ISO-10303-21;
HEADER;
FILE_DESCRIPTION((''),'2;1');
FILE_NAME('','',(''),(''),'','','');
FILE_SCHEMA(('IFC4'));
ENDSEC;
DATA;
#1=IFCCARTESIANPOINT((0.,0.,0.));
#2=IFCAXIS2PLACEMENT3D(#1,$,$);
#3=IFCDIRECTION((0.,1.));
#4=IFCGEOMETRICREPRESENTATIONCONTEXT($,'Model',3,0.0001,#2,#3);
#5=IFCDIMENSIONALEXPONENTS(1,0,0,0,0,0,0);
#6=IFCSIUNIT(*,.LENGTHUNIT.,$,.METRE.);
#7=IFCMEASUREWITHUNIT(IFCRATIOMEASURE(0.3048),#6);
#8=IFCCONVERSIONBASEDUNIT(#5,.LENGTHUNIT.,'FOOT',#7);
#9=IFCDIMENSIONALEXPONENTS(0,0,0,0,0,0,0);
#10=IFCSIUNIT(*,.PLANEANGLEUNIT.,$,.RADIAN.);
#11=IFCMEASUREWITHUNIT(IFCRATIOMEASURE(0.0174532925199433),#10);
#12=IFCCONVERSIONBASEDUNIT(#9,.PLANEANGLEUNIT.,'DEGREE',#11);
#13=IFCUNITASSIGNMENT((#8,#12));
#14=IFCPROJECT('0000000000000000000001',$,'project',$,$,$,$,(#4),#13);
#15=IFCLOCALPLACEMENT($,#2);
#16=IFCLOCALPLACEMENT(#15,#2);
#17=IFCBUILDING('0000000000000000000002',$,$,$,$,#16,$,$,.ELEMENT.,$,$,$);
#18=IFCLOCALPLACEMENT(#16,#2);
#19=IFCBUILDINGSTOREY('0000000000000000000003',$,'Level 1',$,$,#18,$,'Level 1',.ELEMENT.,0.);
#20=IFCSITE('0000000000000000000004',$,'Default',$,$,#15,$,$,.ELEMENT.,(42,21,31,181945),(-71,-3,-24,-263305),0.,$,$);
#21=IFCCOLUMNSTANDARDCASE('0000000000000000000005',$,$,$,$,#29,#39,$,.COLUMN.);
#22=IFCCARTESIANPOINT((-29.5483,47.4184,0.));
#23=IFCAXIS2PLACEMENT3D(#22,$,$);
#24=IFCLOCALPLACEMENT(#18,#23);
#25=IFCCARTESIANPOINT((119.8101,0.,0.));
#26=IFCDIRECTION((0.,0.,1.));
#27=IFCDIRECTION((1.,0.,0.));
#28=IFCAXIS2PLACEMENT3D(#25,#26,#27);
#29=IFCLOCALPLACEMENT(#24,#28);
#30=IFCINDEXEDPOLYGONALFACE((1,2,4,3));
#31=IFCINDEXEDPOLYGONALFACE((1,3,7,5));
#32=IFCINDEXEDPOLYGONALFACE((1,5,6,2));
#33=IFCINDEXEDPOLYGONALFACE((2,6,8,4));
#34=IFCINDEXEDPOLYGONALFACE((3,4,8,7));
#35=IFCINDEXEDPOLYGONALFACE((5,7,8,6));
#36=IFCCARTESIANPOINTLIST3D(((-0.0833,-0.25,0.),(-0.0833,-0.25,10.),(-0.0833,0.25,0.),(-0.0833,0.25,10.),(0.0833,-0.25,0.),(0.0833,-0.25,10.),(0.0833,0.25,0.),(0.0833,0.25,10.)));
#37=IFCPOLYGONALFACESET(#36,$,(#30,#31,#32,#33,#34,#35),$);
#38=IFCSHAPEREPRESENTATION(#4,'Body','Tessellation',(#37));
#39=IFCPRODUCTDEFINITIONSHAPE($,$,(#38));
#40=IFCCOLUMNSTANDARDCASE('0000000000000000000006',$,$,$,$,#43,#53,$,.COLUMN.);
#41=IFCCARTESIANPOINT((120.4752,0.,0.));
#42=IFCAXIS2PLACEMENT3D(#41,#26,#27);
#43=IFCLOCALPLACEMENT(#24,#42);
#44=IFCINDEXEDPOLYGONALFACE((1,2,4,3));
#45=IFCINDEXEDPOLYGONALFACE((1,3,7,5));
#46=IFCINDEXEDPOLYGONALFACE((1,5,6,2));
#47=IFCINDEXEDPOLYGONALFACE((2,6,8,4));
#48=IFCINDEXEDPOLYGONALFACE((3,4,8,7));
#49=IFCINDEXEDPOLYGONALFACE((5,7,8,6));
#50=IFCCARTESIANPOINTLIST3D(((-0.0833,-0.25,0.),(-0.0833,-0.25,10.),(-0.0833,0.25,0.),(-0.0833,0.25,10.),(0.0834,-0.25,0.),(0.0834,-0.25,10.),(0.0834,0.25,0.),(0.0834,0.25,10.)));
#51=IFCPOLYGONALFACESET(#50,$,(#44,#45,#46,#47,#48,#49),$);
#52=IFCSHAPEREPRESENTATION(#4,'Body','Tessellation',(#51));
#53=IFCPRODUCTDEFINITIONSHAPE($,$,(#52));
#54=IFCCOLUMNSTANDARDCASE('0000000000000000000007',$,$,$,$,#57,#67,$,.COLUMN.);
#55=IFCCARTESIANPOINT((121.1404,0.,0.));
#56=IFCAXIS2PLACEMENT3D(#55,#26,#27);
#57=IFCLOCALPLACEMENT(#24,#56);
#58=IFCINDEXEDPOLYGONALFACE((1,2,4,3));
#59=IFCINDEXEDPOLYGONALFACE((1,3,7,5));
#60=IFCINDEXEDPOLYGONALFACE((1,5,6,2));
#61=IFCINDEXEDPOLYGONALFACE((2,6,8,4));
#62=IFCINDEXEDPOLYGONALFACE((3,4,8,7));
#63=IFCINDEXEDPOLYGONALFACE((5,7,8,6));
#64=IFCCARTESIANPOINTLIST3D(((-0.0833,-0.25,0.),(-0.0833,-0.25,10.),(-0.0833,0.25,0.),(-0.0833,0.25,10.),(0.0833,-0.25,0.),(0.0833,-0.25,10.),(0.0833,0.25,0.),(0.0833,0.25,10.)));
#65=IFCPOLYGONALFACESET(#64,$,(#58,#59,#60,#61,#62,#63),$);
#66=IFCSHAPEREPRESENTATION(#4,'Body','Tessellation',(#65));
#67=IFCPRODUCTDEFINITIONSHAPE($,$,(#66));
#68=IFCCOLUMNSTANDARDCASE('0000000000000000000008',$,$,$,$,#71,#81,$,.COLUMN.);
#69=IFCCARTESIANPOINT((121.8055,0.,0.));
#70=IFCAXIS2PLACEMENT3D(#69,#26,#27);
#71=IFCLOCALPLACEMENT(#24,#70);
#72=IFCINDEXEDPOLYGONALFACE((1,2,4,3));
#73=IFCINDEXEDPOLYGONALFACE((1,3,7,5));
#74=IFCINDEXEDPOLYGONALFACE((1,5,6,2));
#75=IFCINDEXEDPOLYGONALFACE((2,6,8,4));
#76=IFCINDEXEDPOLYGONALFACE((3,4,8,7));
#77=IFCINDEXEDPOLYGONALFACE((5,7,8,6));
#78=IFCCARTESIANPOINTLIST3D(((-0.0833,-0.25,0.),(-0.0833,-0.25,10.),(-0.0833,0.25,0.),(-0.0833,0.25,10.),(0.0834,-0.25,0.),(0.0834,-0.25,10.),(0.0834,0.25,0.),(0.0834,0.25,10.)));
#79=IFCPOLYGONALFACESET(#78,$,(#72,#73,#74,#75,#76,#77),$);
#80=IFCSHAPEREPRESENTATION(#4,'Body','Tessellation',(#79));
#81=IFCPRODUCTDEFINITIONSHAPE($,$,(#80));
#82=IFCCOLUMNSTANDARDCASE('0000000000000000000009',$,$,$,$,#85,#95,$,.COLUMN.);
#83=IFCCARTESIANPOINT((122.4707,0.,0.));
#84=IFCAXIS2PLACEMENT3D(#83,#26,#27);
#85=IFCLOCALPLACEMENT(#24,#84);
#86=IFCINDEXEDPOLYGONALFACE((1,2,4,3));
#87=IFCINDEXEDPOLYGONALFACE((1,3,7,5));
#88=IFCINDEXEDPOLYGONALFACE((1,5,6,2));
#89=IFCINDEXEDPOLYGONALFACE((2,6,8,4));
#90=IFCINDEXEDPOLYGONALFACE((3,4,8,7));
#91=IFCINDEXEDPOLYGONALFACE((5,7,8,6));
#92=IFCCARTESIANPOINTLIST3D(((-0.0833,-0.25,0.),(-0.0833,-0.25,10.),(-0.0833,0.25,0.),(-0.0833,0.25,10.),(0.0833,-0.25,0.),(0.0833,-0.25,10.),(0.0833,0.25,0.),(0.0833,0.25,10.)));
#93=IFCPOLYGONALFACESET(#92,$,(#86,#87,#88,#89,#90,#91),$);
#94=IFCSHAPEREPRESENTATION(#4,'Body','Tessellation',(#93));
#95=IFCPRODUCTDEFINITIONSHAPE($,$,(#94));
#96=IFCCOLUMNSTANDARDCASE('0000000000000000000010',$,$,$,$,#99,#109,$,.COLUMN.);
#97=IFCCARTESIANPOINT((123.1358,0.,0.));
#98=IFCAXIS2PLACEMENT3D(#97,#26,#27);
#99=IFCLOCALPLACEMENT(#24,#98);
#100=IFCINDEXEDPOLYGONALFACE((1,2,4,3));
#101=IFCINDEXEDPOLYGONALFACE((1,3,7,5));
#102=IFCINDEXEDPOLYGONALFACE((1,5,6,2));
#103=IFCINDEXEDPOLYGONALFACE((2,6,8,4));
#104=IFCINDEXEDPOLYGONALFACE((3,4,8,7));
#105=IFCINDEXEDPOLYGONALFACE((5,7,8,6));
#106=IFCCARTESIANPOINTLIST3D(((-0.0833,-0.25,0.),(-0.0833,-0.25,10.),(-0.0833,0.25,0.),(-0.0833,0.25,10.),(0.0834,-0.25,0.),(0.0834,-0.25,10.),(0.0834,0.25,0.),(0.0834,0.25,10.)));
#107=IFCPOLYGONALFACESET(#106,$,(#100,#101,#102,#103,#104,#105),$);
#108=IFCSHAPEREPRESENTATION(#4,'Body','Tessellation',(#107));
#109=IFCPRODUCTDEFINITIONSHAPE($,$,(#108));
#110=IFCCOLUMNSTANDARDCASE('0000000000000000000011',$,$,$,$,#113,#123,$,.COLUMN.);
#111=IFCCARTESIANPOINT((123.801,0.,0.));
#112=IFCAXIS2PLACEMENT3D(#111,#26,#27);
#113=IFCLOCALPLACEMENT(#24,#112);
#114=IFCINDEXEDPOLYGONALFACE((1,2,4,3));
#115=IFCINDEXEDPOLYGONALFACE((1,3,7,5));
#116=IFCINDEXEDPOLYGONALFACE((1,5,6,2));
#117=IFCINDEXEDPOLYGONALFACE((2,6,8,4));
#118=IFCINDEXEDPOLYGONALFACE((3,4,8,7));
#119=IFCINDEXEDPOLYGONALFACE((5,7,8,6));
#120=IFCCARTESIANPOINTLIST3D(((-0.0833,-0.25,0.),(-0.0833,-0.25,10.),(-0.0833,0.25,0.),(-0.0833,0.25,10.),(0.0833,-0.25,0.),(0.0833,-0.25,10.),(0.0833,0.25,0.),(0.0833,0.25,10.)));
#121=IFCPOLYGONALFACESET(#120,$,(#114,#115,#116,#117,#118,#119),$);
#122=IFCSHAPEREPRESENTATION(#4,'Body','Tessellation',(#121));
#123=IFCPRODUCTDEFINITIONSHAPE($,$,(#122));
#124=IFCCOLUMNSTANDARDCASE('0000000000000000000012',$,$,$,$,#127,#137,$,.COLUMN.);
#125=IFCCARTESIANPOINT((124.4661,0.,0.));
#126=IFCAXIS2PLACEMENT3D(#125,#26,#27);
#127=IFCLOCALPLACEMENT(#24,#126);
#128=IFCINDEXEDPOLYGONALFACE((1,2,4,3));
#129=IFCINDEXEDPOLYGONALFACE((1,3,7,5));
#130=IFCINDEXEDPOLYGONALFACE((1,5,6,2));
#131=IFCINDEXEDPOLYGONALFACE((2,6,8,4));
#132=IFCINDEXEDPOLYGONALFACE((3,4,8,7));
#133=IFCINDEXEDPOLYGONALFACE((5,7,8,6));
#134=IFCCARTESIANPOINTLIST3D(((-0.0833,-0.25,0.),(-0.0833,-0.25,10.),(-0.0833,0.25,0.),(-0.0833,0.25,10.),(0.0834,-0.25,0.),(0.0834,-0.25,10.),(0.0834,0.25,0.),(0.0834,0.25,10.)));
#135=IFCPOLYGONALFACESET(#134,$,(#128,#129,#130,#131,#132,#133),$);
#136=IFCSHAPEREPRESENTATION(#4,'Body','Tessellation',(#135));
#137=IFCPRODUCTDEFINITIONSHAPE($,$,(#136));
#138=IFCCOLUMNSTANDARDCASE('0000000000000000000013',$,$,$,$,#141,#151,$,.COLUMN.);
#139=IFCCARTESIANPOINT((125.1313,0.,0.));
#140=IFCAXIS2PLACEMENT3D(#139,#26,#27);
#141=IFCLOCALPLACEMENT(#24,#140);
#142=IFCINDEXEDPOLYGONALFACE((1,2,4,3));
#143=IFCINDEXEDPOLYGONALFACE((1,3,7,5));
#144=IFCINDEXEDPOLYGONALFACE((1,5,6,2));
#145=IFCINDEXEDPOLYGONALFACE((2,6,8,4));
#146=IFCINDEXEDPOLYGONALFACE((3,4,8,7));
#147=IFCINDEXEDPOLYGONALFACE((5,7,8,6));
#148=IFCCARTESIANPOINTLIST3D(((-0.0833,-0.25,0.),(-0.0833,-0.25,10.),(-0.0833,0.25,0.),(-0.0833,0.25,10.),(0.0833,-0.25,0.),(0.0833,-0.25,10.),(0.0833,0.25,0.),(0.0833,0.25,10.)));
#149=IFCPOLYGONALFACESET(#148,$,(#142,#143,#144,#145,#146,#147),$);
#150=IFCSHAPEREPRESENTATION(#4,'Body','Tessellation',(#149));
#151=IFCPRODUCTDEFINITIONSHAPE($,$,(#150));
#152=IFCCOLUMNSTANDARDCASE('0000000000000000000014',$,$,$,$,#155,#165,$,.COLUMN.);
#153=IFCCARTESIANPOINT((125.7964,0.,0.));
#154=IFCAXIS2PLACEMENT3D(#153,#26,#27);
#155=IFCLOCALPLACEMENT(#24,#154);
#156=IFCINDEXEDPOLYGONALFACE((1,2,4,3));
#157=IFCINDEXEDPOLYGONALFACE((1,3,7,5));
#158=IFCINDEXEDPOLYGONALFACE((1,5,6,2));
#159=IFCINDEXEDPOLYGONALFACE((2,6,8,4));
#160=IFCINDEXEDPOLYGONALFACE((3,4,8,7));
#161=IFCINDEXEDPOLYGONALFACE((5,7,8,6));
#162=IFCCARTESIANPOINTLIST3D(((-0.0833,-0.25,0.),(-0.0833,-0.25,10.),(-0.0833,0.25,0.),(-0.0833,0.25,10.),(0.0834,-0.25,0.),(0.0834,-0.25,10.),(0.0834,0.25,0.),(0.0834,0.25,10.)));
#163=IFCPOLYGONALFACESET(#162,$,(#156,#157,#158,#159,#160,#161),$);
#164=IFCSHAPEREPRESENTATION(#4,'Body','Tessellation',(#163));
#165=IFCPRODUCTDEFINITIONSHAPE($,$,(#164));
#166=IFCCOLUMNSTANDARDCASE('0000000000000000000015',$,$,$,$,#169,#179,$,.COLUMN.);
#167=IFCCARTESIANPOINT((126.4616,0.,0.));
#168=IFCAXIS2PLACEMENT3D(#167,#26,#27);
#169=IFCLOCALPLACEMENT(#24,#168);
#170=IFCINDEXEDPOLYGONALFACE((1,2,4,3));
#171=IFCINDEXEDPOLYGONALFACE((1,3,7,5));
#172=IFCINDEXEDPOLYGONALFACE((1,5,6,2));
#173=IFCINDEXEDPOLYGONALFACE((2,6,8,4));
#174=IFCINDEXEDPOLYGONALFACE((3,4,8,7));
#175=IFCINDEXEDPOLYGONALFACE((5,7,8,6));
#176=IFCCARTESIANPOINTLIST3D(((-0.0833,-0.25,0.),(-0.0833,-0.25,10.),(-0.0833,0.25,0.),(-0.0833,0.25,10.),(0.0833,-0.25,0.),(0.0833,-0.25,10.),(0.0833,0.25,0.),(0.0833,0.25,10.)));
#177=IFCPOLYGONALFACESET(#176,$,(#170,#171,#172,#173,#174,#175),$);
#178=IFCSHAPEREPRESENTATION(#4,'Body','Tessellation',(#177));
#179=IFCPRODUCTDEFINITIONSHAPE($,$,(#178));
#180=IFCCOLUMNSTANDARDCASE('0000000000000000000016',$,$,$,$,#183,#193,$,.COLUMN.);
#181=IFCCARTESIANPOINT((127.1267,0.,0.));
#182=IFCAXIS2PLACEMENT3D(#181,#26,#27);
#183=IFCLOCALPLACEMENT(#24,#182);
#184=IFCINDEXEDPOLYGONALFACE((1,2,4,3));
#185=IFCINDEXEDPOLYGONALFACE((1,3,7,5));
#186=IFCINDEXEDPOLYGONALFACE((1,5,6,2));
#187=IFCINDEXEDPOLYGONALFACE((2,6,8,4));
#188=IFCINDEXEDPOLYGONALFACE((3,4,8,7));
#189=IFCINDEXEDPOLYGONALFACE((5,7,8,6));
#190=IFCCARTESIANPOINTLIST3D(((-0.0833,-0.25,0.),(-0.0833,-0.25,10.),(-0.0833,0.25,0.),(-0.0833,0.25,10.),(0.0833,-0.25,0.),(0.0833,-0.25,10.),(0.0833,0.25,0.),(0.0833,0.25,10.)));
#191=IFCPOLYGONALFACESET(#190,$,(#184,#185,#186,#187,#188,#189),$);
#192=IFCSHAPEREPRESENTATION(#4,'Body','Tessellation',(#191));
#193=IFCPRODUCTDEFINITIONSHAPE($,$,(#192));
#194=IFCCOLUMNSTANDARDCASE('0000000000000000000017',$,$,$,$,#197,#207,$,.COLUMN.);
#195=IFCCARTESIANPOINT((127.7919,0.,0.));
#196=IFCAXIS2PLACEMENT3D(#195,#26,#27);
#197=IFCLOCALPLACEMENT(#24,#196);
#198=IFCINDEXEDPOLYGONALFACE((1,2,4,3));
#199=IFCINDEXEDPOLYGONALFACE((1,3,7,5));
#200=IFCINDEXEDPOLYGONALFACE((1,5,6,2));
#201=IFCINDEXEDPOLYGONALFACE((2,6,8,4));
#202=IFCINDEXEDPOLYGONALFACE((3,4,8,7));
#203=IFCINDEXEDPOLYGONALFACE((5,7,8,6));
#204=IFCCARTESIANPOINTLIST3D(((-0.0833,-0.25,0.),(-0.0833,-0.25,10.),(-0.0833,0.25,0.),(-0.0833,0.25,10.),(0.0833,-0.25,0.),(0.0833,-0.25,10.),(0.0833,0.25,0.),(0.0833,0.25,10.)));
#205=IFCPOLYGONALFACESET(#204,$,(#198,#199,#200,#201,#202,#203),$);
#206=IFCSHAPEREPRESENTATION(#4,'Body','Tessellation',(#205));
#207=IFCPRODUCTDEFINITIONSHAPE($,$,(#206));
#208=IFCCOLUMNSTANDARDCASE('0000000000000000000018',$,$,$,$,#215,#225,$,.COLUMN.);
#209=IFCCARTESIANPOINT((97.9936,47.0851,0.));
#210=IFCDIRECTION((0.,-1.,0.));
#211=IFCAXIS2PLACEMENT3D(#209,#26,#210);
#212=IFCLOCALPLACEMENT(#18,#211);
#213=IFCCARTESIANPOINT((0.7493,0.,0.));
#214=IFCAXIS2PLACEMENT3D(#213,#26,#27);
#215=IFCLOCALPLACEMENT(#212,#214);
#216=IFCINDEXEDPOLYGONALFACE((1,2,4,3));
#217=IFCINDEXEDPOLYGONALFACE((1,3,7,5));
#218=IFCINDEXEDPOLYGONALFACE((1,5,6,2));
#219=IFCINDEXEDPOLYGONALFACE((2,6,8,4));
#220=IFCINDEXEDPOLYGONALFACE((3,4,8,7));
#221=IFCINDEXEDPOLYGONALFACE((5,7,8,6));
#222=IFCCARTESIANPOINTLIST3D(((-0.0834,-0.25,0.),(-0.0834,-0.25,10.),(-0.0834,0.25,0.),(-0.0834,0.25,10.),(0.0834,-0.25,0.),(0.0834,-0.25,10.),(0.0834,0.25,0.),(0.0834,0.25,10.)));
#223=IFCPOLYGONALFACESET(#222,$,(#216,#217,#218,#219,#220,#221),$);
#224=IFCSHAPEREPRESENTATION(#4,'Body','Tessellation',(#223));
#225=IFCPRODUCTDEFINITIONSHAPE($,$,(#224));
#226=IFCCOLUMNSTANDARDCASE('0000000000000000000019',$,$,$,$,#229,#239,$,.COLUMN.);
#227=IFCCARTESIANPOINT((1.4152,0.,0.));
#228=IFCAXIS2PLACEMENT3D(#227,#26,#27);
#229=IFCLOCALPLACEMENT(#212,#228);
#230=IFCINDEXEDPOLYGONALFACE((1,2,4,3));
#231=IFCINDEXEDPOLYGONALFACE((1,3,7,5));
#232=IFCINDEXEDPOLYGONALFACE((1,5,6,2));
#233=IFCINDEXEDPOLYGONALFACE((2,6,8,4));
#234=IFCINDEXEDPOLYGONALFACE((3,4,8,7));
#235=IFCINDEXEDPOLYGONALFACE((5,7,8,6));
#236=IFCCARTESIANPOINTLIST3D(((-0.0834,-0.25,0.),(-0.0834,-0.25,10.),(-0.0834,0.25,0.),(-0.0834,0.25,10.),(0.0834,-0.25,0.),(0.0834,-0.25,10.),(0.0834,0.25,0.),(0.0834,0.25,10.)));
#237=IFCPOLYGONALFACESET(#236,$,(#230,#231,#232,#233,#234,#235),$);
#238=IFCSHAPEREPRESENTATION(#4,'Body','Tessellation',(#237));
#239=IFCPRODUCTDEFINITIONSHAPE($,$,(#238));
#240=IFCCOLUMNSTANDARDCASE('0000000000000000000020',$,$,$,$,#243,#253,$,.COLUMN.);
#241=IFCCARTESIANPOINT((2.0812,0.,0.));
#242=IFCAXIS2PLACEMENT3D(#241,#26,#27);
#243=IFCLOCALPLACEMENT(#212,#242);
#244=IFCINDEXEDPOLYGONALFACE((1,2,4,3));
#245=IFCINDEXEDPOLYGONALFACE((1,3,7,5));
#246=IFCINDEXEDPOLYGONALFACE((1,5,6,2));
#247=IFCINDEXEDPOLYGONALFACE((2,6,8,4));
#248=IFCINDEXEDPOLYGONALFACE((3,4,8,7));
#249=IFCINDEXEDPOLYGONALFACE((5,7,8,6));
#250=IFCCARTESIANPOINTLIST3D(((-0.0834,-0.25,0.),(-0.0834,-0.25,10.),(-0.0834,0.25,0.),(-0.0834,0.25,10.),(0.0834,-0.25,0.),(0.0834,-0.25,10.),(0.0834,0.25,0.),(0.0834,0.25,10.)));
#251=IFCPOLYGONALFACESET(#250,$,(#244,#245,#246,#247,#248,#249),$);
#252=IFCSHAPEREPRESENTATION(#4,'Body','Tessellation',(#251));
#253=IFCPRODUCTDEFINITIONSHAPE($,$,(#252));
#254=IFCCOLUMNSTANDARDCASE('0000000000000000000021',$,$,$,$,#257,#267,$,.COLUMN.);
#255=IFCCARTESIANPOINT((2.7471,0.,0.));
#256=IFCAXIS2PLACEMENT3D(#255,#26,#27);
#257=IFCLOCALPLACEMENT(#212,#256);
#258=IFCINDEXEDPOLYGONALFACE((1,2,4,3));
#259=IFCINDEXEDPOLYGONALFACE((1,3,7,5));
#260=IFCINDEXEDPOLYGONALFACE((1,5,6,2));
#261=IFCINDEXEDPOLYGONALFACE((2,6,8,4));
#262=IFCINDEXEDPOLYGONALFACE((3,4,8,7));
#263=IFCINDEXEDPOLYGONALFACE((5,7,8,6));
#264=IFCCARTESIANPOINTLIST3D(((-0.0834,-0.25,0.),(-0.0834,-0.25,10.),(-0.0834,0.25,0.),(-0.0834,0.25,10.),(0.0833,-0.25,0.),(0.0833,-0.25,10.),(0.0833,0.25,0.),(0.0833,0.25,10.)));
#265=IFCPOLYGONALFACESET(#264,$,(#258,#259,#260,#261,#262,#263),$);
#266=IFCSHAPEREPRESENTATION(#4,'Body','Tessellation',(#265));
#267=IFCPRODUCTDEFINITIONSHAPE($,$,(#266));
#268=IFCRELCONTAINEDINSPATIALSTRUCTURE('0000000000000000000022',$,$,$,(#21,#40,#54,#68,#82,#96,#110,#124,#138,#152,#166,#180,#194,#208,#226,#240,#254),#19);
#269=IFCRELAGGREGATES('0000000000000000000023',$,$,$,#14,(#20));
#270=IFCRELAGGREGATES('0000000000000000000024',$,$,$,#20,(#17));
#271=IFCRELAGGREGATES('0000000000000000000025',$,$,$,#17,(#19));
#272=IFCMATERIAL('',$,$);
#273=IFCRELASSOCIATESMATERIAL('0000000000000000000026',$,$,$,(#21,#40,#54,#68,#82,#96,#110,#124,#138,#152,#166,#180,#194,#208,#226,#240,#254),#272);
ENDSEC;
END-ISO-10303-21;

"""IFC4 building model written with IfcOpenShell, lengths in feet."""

from ifc_helpers import new_model, entity, si_unit, converted_unit, direction, frame, origin, place, context, project, spatial, rectangle, extrude, material, element, save


model = new_model("IFC4")

# Units and contexts
model_context = context("Model", 3, precision=0.0001, world=origin(), true_north=direction((0.0, 1.0)))
ifc_project = project(units=[converted_unit("LENGTHUNIT", "FOOT", entity("IfcRatioMeasure", 0.3048), si_unit("LENGTHUNIT", "METRE"), dimensions=[1, 0, 0, 0, 0, 0, 0]), converted_unit("PLANEANGLEUNIT", "DEGREE", entity("IfcRatioMeasure", 0.0174532925199433), si_unit("PLANEANGLEUNIT", "RADIAN"), dimensions=[0, 0, 0, 0, 0, 0, 0])], contexts=[model_context])

# Site, building, storey
site_placement = place(None, origin())
site = spatial("IfcSite", under=ifc_project, at=site_placement, Name="Default", CompositionType="ELEMENT", RefLatitude=(42, 21, 31, 181945), RefLongitude=(-71, -3, -24, -263305), RefElevation=0.0)
building_placement = place(site_placement, origin())
building = spatial("IfcBuilding", under=site, at=building_placement, CompositionType="ELEMENT")
storey_placement = place(building_placement, origin())
storey = spatial("IfcBuildingStorey", under=building, at=storey_placement, Name="Level 1", LongName="Level 1", CompositionType="ELEMENT", Elevation=0.0)

# Columns
ifc_material_1 = material(Name="")
placement = place(storey_placement, frame((-29.5483, 47.4184, 0.0)))
for number, where, z_axis, x_axis in (
    (1, (119.8101, 0.0, 0.0), (0.0, 0.0, 1.0), (1.0, 0.0, 0.0)),
    (2, (120.4752, 0.0, 0.0), (0.0, 0.0, 1.0), (1.0, 0.0, 0.0)),
    (3, (121.1404, 0.0, 0.0), (0.0, 0.0, 1.0), (1.0, 0.0, 0.0)),
    (4, (121.8055, 0.0, 0.0), (0.0, 0.0, 1.0), (1.0, 0.0, 0.0)),
    (5, (122.4707, 0.0, 0.0), (0.0, 0.0, 1.0), (1.0, 0.0, 0.0)),
    (6, (123.1358, 0.0, 0.0), (0.0, 0.0, 1.0), (1.0, 0.0, 0.0)),
    (7, (123.801, 0.0, 0.0), (0.0, 0.0, 1.0), (1.0, 0.0, 0.0)),
    (8, (124.4661, 0.0, 0.0), (0.0, 0.0, 1.0), (1.0, 0.0, 0.0)),
    (9, (125.1313, 0.0, 0.0), (0.0, 0.0, 1.0), (1.0, 0.0, 0.0)),
    (10, (125.7964, 0.0, 0.0), (0.0, 0.0, 1.0), (1.0, 0.0, 0.0)),
    (11, (126.4616, 0.0, 0.0), (0.0, 0.0, 1.0), (1.0, 0.0, 0.0)),
    (12, (127.1267, 0.0, 0.0), (0.0, 0.0, 1.0), (1.0, 0.0, 0.0)),
    (13, (127.7919, 0.0, 0.0), (0.0, 0.0, 1.0), (1.0, 0.0, 0.0)),
):
    element("IfcColumnStandardCase", number, at=place(placement, frame(where, z_axis=z_axis, x_axis=x_axis)), inside=storey, material=ifc_material_1, PredefinedType="COLUMN", context=model_context, shape_type="SweptSolid", body=[
        extrude(rectangle(XDim=0.1667, YDim=0.5), origin(), (0.0, 0.0, 1.0), 10.0),
    ])
wall_placement = place(storey_placement, frame((97.9936, 47.0851, 0.0), z_axis=(0.0, 0.0, 1.0), x_axis=(0.0, -1.0, 0.0)))
for number, where, z_axis, x_axis in (
    (14, (0.7493, 0.0, 0.0), (0.0, 0.0, 1.0), (1.0, 0.0, 0.0)),
    (15, (1.4152, 0.0, 0.0), (0.0, 0.0, 1.0), (1.0, 0.0, 0.0)),
    (16, (2.0812, 0.0, 0.0), (0.0, 0.0, 1.0), (1.0, 0.0, 0.0)),
    (17, (2.7471, 0.0, 0.0), (0.0, 0.0, 1.0), (1.0, 0.0, 0.0)),
):
    element("IfcColumnStandardCase", number, at=place(wall_placement, frame(where, z_axis=z_axis, x_axis=x_axis)), inside=storey, material=ifc_material_1, PredefinedType="COLUMN", context=model_context, shape_type="SweptSolid", body=[
        extrude(rectangle(XDim=0.1667, YDim=0.5), origin(), (0.0, 0.0, 1.0), 10.0),
    ])

save(model, "model.ifc")
